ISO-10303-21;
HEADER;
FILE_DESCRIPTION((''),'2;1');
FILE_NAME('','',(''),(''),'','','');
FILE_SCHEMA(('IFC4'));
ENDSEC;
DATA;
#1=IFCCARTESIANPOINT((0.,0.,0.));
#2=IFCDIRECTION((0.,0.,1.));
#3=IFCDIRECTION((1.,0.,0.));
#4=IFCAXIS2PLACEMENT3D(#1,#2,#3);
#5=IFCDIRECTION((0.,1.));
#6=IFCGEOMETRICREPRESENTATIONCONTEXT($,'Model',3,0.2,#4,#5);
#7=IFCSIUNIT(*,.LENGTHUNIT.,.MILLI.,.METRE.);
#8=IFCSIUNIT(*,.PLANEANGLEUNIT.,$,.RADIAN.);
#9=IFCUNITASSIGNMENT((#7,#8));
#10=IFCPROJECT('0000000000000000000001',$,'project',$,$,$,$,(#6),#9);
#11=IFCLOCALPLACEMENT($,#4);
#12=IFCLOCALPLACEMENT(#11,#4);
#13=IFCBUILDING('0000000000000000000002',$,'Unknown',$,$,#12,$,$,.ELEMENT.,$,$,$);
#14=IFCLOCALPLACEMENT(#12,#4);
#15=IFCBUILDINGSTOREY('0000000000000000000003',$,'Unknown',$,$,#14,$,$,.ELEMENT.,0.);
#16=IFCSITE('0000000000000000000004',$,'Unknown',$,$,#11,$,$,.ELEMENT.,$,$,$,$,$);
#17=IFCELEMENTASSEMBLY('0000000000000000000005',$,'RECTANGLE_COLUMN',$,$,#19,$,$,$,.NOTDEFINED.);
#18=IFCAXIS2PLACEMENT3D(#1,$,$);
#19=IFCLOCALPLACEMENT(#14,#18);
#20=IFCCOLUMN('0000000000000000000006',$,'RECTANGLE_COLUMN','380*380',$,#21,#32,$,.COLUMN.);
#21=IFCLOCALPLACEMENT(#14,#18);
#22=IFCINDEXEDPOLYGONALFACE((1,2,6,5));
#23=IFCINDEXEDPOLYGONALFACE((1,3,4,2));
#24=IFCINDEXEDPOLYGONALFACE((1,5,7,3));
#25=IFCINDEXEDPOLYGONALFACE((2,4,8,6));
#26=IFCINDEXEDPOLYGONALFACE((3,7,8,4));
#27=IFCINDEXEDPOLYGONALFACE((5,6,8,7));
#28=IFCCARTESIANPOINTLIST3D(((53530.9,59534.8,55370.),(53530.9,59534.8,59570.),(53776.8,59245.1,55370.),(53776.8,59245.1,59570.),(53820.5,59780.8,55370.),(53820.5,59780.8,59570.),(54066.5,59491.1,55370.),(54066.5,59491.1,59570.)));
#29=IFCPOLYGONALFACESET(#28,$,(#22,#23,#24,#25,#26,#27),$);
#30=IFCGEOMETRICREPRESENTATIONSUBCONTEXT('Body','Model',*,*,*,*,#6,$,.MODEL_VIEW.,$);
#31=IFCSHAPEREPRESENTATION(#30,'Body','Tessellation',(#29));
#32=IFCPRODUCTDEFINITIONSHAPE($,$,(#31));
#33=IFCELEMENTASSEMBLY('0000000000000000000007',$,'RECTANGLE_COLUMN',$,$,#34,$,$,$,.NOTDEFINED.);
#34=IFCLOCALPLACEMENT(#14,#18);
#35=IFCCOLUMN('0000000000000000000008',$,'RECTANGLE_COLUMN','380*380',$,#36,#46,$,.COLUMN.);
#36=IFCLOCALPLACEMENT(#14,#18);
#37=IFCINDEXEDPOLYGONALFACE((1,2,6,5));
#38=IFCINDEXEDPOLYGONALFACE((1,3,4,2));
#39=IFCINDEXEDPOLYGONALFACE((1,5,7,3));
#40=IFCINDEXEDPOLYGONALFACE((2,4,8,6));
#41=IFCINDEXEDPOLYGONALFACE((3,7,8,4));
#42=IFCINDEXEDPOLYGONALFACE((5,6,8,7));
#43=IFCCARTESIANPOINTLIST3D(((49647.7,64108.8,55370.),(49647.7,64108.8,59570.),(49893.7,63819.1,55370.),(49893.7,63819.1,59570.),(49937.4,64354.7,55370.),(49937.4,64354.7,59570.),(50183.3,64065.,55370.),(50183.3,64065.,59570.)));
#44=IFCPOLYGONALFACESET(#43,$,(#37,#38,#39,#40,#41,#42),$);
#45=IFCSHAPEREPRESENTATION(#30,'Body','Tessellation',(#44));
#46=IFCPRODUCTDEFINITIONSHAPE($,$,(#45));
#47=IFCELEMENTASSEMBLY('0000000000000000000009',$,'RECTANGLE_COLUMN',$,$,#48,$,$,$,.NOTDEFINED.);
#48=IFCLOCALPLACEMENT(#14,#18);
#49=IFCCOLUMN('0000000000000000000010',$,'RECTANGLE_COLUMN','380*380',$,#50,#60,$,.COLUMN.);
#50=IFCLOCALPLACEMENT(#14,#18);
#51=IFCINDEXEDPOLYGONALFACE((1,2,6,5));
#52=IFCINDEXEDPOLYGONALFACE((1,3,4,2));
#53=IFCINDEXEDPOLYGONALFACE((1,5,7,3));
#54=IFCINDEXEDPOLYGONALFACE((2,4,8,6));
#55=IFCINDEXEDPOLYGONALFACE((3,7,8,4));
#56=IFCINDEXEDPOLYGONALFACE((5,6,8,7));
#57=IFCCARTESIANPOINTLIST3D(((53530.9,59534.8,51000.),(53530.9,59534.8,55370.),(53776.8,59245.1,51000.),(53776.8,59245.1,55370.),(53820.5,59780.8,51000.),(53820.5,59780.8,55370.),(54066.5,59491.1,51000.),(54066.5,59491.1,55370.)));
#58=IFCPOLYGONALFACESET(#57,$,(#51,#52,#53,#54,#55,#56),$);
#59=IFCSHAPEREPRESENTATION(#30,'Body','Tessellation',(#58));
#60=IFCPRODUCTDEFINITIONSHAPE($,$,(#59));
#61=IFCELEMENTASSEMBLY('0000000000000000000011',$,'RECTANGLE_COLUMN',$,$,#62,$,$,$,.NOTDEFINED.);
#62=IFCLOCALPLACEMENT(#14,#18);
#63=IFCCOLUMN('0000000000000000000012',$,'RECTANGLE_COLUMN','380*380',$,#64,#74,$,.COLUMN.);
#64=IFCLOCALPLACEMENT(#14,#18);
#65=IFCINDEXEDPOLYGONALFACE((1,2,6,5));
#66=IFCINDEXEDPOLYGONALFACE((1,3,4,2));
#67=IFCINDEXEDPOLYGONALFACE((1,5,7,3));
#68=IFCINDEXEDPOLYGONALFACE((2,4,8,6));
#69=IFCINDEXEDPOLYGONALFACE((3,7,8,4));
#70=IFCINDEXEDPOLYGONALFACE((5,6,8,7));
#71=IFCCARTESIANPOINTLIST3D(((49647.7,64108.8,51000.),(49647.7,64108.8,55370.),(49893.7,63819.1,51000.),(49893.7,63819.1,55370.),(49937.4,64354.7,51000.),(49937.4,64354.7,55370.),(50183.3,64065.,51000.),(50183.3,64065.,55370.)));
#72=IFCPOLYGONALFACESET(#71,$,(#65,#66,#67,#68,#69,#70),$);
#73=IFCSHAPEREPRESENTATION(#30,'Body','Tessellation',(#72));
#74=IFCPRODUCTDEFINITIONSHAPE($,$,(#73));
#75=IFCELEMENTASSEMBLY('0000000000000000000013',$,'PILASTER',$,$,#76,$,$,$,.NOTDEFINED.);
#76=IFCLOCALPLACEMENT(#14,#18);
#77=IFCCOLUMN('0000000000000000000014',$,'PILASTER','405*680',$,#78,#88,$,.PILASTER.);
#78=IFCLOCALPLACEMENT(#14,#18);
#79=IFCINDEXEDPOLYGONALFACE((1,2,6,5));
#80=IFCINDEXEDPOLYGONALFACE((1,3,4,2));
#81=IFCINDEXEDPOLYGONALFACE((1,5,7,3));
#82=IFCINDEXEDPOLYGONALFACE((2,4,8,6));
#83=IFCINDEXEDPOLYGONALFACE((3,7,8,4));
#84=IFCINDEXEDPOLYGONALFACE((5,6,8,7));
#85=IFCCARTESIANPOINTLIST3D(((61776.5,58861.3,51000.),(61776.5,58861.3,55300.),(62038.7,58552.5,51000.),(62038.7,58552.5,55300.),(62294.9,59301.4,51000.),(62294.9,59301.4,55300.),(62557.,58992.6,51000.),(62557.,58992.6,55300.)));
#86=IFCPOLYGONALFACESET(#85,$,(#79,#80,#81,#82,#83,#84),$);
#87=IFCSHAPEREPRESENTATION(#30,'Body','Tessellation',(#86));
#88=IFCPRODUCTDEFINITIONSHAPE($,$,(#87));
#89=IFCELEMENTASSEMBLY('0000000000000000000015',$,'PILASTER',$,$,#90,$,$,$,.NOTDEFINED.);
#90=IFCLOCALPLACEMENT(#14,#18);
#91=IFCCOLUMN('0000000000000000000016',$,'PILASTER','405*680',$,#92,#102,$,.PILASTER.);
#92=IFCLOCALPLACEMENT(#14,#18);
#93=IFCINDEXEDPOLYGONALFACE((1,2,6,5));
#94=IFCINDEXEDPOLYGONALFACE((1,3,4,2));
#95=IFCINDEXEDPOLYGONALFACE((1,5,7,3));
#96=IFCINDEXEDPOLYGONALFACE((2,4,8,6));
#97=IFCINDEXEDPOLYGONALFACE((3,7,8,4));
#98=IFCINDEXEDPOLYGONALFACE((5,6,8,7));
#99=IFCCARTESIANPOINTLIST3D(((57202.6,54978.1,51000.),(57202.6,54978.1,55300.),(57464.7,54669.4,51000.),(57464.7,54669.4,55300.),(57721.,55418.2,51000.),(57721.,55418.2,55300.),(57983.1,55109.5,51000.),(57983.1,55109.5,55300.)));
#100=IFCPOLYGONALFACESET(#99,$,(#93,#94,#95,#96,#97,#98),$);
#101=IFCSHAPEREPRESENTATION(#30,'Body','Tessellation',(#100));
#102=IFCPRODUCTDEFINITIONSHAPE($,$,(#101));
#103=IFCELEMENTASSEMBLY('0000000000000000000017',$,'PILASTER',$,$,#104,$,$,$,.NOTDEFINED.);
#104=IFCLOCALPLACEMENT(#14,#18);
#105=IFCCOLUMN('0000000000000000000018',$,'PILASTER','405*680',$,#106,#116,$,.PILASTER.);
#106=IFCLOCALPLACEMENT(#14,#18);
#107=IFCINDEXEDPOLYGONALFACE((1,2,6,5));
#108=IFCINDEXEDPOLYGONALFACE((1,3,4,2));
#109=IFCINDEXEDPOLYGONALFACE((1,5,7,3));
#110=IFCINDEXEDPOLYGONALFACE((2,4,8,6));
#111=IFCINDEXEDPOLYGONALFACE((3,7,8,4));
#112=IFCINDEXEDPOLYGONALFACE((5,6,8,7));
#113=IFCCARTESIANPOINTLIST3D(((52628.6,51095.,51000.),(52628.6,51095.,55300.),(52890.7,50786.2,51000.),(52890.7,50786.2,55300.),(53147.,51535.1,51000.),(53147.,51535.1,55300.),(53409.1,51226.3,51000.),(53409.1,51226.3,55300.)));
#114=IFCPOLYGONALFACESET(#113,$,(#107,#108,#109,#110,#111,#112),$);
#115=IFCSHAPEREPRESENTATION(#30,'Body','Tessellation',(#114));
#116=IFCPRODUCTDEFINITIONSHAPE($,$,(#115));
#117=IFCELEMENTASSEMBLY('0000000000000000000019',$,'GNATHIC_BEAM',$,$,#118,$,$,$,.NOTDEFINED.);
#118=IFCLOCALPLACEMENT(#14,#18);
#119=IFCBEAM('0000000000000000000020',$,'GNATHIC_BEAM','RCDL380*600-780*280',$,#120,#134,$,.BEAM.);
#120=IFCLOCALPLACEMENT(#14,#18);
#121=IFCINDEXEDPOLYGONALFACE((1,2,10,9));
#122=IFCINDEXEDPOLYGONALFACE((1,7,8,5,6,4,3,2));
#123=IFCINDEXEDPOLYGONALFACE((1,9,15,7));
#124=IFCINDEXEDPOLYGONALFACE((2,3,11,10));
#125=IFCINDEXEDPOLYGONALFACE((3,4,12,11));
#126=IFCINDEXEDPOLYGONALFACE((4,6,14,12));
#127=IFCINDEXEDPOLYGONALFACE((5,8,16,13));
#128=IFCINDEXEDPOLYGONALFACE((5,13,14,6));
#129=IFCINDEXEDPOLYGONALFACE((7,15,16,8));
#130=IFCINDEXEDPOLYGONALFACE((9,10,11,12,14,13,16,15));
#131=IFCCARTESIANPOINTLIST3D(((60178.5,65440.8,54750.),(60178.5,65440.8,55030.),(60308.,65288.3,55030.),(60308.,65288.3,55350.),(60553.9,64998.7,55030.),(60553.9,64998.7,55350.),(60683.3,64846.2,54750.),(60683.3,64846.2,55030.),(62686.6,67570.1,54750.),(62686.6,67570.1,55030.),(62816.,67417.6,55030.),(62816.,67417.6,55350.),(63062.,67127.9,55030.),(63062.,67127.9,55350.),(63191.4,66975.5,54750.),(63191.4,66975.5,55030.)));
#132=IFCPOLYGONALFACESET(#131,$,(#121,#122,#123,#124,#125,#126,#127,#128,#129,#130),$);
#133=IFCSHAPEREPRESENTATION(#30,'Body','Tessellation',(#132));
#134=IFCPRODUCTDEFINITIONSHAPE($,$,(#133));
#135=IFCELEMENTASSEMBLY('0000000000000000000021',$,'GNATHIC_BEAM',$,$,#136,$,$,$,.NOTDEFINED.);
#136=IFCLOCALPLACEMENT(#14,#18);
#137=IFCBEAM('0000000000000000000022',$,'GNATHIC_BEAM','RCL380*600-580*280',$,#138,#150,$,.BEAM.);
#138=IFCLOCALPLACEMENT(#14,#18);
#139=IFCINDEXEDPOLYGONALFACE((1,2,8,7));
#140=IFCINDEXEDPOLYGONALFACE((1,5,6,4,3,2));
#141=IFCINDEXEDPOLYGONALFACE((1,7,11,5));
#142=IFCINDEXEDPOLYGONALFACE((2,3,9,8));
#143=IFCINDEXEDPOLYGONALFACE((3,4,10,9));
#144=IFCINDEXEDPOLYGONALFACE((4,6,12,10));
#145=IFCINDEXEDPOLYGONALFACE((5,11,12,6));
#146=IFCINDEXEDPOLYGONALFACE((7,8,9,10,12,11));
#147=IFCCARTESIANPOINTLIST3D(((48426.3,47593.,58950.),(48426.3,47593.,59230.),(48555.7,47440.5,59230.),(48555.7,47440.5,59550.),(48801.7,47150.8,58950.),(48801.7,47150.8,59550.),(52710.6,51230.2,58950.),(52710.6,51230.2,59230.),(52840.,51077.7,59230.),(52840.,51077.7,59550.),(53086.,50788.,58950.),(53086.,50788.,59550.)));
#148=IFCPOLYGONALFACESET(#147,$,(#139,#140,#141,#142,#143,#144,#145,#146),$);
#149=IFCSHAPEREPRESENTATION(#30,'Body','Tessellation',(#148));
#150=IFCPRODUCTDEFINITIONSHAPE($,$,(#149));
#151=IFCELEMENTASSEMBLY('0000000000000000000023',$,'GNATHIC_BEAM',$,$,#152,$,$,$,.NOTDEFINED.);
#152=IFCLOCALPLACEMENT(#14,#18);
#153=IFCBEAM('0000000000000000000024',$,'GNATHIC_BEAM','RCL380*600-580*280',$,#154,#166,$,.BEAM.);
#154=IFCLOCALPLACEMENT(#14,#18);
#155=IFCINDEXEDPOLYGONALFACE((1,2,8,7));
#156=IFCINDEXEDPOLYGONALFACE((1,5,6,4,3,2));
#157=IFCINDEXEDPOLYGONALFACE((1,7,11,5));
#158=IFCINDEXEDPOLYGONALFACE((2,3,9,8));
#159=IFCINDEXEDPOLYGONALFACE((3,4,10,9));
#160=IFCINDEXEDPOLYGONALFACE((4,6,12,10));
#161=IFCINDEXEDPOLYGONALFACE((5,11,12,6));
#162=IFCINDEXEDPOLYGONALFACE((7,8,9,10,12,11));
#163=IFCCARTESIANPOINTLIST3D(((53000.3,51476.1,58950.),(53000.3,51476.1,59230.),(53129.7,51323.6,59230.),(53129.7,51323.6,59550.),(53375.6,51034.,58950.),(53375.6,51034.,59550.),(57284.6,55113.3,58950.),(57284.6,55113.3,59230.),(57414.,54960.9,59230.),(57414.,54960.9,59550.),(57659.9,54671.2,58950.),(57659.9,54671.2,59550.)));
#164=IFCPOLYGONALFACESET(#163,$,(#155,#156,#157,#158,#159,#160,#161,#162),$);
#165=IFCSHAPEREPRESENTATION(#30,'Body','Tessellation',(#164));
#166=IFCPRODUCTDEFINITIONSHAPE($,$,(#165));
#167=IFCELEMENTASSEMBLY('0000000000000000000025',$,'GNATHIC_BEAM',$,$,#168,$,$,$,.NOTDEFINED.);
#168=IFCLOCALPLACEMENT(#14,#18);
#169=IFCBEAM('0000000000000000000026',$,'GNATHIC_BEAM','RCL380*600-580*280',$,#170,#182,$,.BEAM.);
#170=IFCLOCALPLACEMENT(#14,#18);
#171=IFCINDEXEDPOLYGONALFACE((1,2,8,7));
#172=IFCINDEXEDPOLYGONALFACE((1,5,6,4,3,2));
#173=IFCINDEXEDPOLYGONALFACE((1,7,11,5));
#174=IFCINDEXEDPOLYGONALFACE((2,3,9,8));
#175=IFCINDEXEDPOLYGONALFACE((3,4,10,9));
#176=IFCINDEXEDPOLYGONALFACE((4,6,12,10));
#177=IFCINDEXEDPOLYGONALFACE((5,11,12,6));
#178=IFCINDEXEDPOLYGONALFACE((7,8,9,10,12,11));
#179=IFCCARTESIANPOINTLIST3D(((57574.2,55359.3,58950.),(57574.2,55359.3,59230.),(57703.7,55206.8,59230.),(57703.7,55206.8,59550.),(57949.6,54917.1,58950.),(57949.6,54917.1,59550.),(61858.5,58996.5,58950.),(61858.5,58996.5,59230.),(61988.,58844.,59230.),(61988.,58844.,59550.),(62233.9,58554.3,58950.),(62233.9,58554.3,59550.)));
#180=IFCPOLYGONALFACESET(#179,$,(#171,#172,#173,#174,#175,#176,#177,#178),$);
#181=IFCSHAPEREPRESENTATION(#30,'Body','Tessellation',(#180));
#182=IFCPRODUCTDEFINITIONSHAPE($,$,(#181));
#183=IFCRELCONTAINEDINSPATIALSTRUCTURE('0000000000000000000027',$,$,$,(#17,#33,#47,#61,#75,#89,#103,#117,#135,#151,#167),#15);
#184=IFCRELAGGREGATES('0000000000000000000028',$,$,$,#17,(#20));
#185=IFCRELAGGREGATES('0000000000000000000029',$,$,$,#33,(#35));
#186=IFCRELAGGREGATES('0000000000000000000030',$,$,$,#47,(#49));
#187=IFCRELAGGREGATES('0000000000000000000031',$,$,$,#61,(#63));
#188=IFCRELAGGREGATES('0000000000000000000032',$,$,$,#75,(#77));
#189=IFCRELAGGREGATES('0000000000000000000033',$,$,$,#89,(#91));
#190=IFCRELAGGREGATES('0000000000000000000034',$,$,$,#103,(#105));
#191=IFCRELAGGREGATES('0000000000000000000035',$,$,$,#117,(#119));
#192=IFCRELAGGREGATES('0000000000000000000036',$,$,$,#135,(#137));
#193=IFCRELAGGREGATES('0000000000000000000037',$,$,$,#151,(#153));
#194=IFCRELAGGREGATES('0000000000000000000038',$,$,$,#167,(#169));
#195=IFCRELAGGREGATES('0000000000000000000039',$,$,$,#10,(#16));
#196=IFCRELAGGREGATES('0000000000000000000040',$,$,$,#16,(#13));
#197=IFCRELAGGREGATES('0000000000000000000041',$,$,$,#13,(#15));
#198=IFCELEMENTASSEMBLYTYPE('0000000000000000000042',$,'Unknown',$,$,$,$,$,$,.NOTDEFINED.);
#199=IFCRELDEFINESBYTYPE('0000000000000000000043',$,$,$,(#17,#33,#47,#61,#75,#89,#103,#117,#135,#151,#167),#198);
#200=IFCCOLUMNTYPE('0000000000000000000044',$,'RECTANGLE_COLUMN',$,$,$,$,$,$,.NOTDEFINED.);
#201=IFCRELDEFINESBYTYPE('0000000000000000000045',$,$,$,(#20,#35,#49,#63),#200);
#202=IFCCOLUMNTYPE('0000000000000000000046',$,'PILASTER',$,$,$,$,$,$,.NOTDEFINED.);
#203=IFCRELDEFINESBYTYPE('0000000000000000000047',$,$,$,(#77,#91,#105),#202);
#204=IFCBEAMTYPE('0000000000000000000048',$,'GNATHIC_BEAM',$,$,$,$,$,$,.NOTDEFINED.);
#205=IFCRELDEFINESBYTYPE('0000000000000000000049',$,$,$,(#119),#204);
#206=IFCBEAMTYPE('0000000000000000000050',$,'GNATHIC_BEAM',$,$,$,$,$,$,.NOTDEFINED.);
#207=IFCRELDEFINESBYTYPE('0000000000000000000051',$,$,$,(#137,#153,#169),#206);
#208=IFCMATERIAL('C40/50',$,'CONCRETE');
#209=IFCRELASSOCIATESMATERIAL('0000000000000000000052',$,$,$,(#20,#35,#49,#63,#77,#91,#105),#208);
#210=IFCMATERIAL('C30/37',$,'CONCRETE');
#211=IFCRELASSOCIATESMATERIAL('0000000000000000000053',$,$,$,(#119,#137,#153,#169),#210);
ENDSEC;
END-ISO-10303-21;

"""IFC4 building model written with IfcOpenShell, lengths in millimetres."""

from ifc_helpers import new_model, si_unit, direction, frame, origin_with_axes, origin_2d_with_axis, place, context, subcontext, project, spatial, polyline, rectangle, outline, extrude, material, material_profile, profile_set, profile_usage, type_object, element, aggregate, save


model = new_model("IFC4")

# Units and contexts
model_context = context("Model", 3, precision=0.2, world=origin_with_axes(), true_north=direction((0.0, 1.0)))
body_context = subcontext(model_context, "Body", "Model", "MODEL_VIEW")
ifc_project = project(units=[si_unit("LENGTHUNIT", "METRE", prefix="MILLI"), si_unit("PLANEANGLEUNIT", "RADIAN")], contexts=[model_context])

# Site, building, storey
site_placement = place(None, origin_with_axes())
site = spatial("IfcSite", under=ifc_project, at=site_placement, Name="Unknown", CompositionType="ELEMENT")
building_placement = place(site_placement, origin_with_axes())
building = spatial("IfcBuilding", under=site, at=building_placement, Name="Unknown", CompositionType="ELEMENT")
storey_placement = place(building_placement, origin_with_axes())
storey = spatial("IfcBuildingStorey", under=building, at=storey_placement, Name="Unknown", CompositionType="ELEMENT", Elevation=0.0)

# Shared definitions
element_assembly_type = type_object("IfcElementAssemblyType", Name="Unknown", PredefinedType="NOTDEFINED")
ifc_material_1 = material(Name="C40/50", Category="CONCRETE")

# Element assemblies, columns
ifc_material_profile_1 = material_profile(ifc_material_1, rectangle(XDim=380.0, YDim=380.0, at=origin_2d_with_axis()), Name="380*380")
ifc_profile_set_1 = profile_set([ifc_material_profile_1])
ifc_profile_usage_1 = profile_usage(ifc_profile_set_1, cardinal=5)
column_type_1 = type_object("IfcColumnType", Name="RECTANGLE_COLUMN")
assembly_1_placement = place(storey_placement, frame((53798.7, 59513.0, 55370.0), z_axis=(-0.762329, -0.64719, 0.0), x_axis=(0.0, 0.0, 1.0)))
assembly_1 = element("IfcElementAssembly", 1, at=assembly_1_placement, inside=storey, type_object=element_assembly_type, Name="RECTANGLE_COLUMN", PredefinedType="NOTDEFINED")
column_1_placement = place(assembly_1_placement, origin_with_axes())
column_1 = element("IfcColumn", 2, at=column_1_placement, type_object=column_type_1, material=ifc_profile_usage_1, Name="RECTANGLE_COLUMN", Description="380*380", PredefinedType="COLUMN", context=body_context, shape_type="SolidModel", body=[
    extrude(rectangle(XDim=380.0, YDim=380.0, at=origin_2d_with_axis()), frame((0.0, 0.0, 0.0), z_axis=(-1.0, 0.0, 0.0), x_axis=(0.0, 0.0, 1.0)), (0.0, 0.0, -1.0), 4200.0),
])
aggregate(assembly_1, [column_1])
assembly_2_placement = place(storey_placement, frame((49915.5, 64086.9, 55370.0), z_axis=(-0.762329, -0.64719, 0.0), x_axis=(0.0, 0.0, 1.0)))
assembly_2 = element("IfcElementAssembly", 3, at=assembly_2_placement, inside=storey, type_object=element_assembly_type, Name="RECTANGLE_COLUMN", PredefinedType="NOTDEFINED")
column_2_placement = place(assembly_2_placement, origin_with_axes())
column_2 = element("IfcColumn", 4, at=column_2_placement, type_object=column_type_1, material=ifc_profile_usage_1, Name="RECTANGLE_COLUMN", Description="380*380", PredefinedType="COLUMN", context=body_context, shape_type="SolidModel", body=[
    extrude(rectangle(XDim=380.0, YDim=380.0, at=origin_2d_with_axis()), frame((0.0, 0.0, 0.0), z_axis=(-1.0, 0.0, 0.0), x_axis=(0.0, 0.0, 1.0)), (0.0, 0.0, -1.0), 4200.0),
])
aggregate(assembly_2, [column_2])
assembly_3_placement = place(storey_placement, frame((53798.7, 59513.0, 51000.0), z_axis=(-0.762329, -0.64719, 0.0), x_axis=(0.0, 0.0, 1.0)))
assembly_3 = element("IfcElementAssembly", 5, at=assembly_3_placement, inside=storey, type_object=element_assembly_type, Name="RECTANGLE_COLUMN", PredefinedType="NOTDEFINED")
column_3_placement = place(assembly_3_placement, origin_with_axes())
column_3 = element("IfcColumn", 6, at=column_3_placement, type_object=column_type_1, material=ifc_profile_usage_1, Name="RECTANGLE_COLUMN", Description="380*380", PredefinedType="COLUMN", context=body_context, shape_type="SolidModel", body=[
    extrude(rectangle(XDim=380.0, YDim=380.0, at=origin_2d_with_axis()), frame((0.0, 0.0, 0.0), z_axis=(-1.0, 0.0, 0.0), x_axis=(0.0, 0.0, 1.0)), (0.0, 0.0, -1.0), 4370.0),
])
aggregate(assembly_3, [column_3])
assembly_4_placement = place(storey_placement, frame((49915.5, 64086.9, 51000.0), z_axis=(-0.762329, -0.64719, 0.0), x_axis=(0.0, 0.0, 1.0)))
assembly_4 = element("IfcElementAssembly", 7, at=assembly_4_placement, inside=storey, type_object=element_assembly_type, Name="RECTANGLE_COLUMN", PredefinedType="NOTDEFINED")
column_4_placement = place(assembly_4_placement, origin_with_axes())
column_4 = element("IfcColumn", 8, at=column_4_placement, type_object=column_type_1, material=ifc_profile_usage_1, Name="RECTANGLE_COLUMN", Description="380*380", PredefinedType="COLUMN", context=body_context, shape_type="SolidModel", body=[
    extrude(rectangle(XDim=380.0, YDim=380.0, at=origin_2d_with_axis()), frame((0.0, 0.0, 0.0), z_axis=(-1.0, 0.0, 0.0), x_axis=(0.0, 0.0, 1.0)), (0.0, 0.0, -1.0), 4370.0),
])
aggregate(assembly_4, [column_4])
assembly_5_placement = place(storey_placement, frame((62166.8, 58926.9, 51000.0), z_axis=(-0.762329, -0.64719, 0.0), x_axis=(0.0, 0.0, 1.0)))
assembly_5 = element("IfcElementAssembly", 9, at=assembly_5_placement, inside=storey, type_object=element_assembly_type, Name="PILASTER", PredefinedType="NOTDEFINED")
ifc_material_profile_2 = material_profile(ifc_material_1, rectangle(XDim=680.0, YDim=405.0, at=origin_2d_with_axis()), Name="405*680")
ifc_profile_set_2 = profile_set([ifc_material_profile_2])
ifc_profile_usage_2 = profile_usage(ifc_profile_set_2, cardinal=6)
column_type_2 = type_object("IfcColumnType", Name="PILASTER")
column_5_placement = place(assembly_5_placement, origin_with_axes())
column_5 = element("IfcColumn", 10, at=column_5_placement, type_object=column_type_2, material=ifc_profile_usage_2, Name="PILASTER", Description="405*680", PredefinedType="PILASTER", context=body_context, shape_type="SolidModel", body=[
    extrude(rectangle(XDim=680.0, YDim=405.0, at=origin_2d_with_axis()), frame((0.0, 0.0, 0.0), z_axis=(-1.0, 0.0, 0.0), x_axis=(0.0, 0.0, 1.0)), (0.0, 0.0, -1.0), 4300.0),
])
aggregate(assembly_5, [column_5])
assembly_6_placement = place(storey_placement, frame((57592.8, 55043.8, 51000.0), z_axis=(-0.762329, -0.64719, 0.0), x_axis=(0.0, 0.0, 1.0)))
assembly_6 = element("IfcElementAssembly", 11, at=assembly_6_placement, inside=storey, type_object=element_assembly_type, Name="PILASTER", PredefinedType="NOTDEFINED")
column_6_placement = place(assembly_6_placement, origin_with_axes())
column_6 = element("IfcColumn", 12, at=column_6_placement, type_object=column_type_2, material=ifc_profile_usage_2, Name="PILASTER", Description="405*680", PredefinedType="PILASTER", context=body_context, shape_type="SolidModel", body=[
    extrude(rectangle(XDim=680.0, YDim=405.0, at=origin_2d_with_axis()), frame((0.0, 0.0, 0.0), z_axis=(-1.0, 0.0, 0.0), x_axis=(0.0, 0.0, 1.0)), (0.0, 0.0, -1.0), 4300.0),
])
aggregate(assembly_6, [column_6])
assembly_7_placement = place(storey_placement, frame((53018.8, 51160.7, 51000.0), z_axis=(-0.762329, -0.64719, 0.0), x_axis=(0.0, 0.0, 1.0)))
assembly_7 = element("IfcElementAssembly", 13, at=assembly_7_placement, inside=storey, type_object=element_assembly_type, Name="PILASTER", PredefinedType="NOTDEFINED")
column_7_placement = place(assembly_7_placement, origin_with_axes())
column_7 = element("IfcColumn", 14, at=column_7_placement, type_object=column_type_2, material=ifc_profile_usage_2, Name="PILASTER", Description="405*680", PredefinedType="PILASTER", context=body_context, shape_type="SolidModel", body=[
    extrude(rectangle(XDim=680.0, YDim=405.0, at=origin_2d_with_axis()), frame((0.0, 0.0, 0.0), z_axis=(-1.0, 0.0, 0.0), x_axis=(0.0, 0.0, 1.0)), (0.0, 0.0, -1.0), 4300.0),
])
aggregate(assembly_7, [column_7])

# Element assemblies, beams
assembly_8_placement = place(storey_placement, frame((60430.9, 65143.5, 55050.0), z_axis=(0.64719, -0.762329, 0.0), x_axis=(0.762329, 0.64719, 0.0)))
assembly_8 = element("IfcElementAssembly", 15, at=assembly_8_placement, inside=storey, type_object=element_assembly_type, Name="GNATHIC_BEAM", PredefinedType="NOTDEFINED")
ifc_material_2 = material(Name="C30/37", Category="CONCRETE")
ifc_material_profile_3 = material_profile(ifc_material_2, outline(polyline([(-390.0, -300.0), (390.0, -300.0), (390.0, -20.0), (190.0, -20.0), (190.0, 300.0), (-190.0, 300.0), (-190.0, -20.0), (-390.0, -20.0), (-390.0, -300.0)])), Name="RCDL380*600-780*280")
ifc_profile_set_3 = profile_set([ifc_material_profile_3])
ifc_profile_usage_3 = profile_usage(ifc_profile_set_3, cardinal=2)
beam_type_1 = type_object("IfcBeamType", Name="GNATHIC_BEAM")
beam_1_placement = place(assembly_8_placement, origin_with_axes())
beam_1 = element("IfcBeam", 16, at=beam_1_placement, type_object=beam_type_1, material=ifc_profile_usage_3, Name="GNATHIC_BEAM", Description="RCDL380*600-780*280", PredefinedType="BEAM", context=body_context, shape_type="SolidModel", body=[
    extrude(outline(polyline([(-390.0, -300.0), (390.0, -300.0), (390.0, -20.0), (190.0, -20.0), (190.0, 300.0), (-190.0, 300.0), (-190.0, -20.0), (-390.0, -20.0), (-390.0, -300.0)])), frame((0.0, 0.0, 0.0), z_axis=(-1.0, 0.0, 0.0), x_axis=(0.0, 0.0, 1.0)), (0.0, 0.0, -1.0), 3290.0),
])
aggregate(assembly_8, [beam_1])
assembly_9_placement = place(storey_placement, frame((52963.0, 50932.9, 59250.0), z_axis=(-0.64719, 0.762329, 0.0), x_axis=(-0.762329, -0.64719, 0.0)))
assembly_9 = element("IfcElementAssembly", 17, at=assembly_9_placement, inside=storey, type_object=element_assembly_type, Name="GNATHIC_BEAM", PredefinedType="NOTDEFINED")
ifc_material_profile_4 = material_profile(ifc_material_2, outline(polyline([(-190.0, -300.0), (390.0, -300.0), (390.0, -20.0), (190.0, -20.0), (190.0, 300.0), (-190.0, 300.0), (-190.0, -300.0)])), Name="RCL380*600-580*280")
ifc_profile_set_4 = profile_set([ifc_material_profile_4])
ifc_profile_usage_4 = profile_usage(ifc_profile_set_4, cardinal=2)
beam_type_2 = type_object("IfcBeamType", Name="GNATHIC_BEAM")
beam_2_placement = place(assembly_9_placement, origin_with_axes())
beam_2 = element("IfcBeam", 18, at=beam_2_placement, type_object=beam_type_2, material=ifc_profile_usage_4, Name="GNATHIC_BEAM", Description="RCL380*600-580*280", PredefinedType="BEAM", context=body_context, shape_type="SolidModel", body=[
    extrude(outline(polyline([(-190.0, -300.0), (390.0, -300.0), (390.0, -20.0), (190.0, -20.0), (190.0, 300.0), (-190.0, 300.0), (-190.0, -300.0)])), frame((0.0, 0.0, 0.0), z_axis=(-1.0, 0.0, 0.0), x_axis=(0.0, 0.0, 1.0)), (0.0, 0.0, -1.0), 5620.0),
])
aggregate(assembly_9, [beam_2])
assembly_10_placement = place(storey_placement, frame((57537.0, 54816.0, 59250.0), z_axis=(-0.64719, 0.762329, 0.0), x_axis=(-0.762329, -0.64719, 0.0)))
assembly_10 = element("IfcElementAssembly", 19, at=assembly_10_placement, inside=storey, type_object=element_assembly_type, Name="GNATHIC_BEAM", PredefinedType="NOTDEFINED")
beam_3_placement = place(assembly_10_placement, origin_with_axes())
beam_3 = element("IfcBeam", 20, at=beam_3_placement, type_object=beam_type_2, material=ifc_profile_usage_4, Name="GNATHIC_BEAM", Description="RCL380*600-580*280", PredefinedType="BEAM", context=body_context, shape_type="SolidModel", body=[
    extrude(outline(polyline([(-190.0, -300.0), (390.0, -300.0), (390.0, -20.0), (190.0, -20.0), (190.0, 300.0), (-190.0, 300.0), (-190.0, -300.0)])), frame((0.0, 0.0, 0.0), z_axis=(-1.0, 0.0, 0.0), x_axis=(0.0, 0.0, 1.0)), (0.0, 0.0, -1.0), 5620.0),
])
aggregate(assembly_10, [beam_3])
assembly_11_placement = place(storey_placement, frame((62110.9, 58699.2, 59250.0), z_axis=(-0.64719, 0.762329, 0.0), x_axis=(-0.762329, -0.64719, 0.0)))
assembly_11 = element("IfcElementAssembly", 21, at=assembly_11_placement, inside=storey, type_object=element_assembly_type, Name="GNATHIC_BEAM", PredefinedType="NOTDEFINED")
beam_4_placement = place(assembly_11_placement, origin_with_axes())
beam_4 = element("IfcBeam", 22, at=beam_4_placement, type_object=beam_type_2, material=ifc_profile_usage_4, Name="GNATHIC_BEAM", Description="RCL380*600-580*280", PredefinedType="BEAM", context=body_context, shape_type="SolidModel", body=[
    extrude(outline(polyline([(-190.0, -300.0), (390.0, -300.0), (390.0, -20.0), (190.0, -20.0), (190.0, 300.0), (-190.0, 300.0), (-190.0, -300.0)])), frame((0.0, 0.0, 0.0), z_axis=(-1.0, 0.0, 0.0), x_axis=(0.0, 0.0, 1.0)), (0.0, 0.0, -1.0), 5620.0),
])
aggregate(assembly_11, [beam_4])

save(model, "model.ifc")
